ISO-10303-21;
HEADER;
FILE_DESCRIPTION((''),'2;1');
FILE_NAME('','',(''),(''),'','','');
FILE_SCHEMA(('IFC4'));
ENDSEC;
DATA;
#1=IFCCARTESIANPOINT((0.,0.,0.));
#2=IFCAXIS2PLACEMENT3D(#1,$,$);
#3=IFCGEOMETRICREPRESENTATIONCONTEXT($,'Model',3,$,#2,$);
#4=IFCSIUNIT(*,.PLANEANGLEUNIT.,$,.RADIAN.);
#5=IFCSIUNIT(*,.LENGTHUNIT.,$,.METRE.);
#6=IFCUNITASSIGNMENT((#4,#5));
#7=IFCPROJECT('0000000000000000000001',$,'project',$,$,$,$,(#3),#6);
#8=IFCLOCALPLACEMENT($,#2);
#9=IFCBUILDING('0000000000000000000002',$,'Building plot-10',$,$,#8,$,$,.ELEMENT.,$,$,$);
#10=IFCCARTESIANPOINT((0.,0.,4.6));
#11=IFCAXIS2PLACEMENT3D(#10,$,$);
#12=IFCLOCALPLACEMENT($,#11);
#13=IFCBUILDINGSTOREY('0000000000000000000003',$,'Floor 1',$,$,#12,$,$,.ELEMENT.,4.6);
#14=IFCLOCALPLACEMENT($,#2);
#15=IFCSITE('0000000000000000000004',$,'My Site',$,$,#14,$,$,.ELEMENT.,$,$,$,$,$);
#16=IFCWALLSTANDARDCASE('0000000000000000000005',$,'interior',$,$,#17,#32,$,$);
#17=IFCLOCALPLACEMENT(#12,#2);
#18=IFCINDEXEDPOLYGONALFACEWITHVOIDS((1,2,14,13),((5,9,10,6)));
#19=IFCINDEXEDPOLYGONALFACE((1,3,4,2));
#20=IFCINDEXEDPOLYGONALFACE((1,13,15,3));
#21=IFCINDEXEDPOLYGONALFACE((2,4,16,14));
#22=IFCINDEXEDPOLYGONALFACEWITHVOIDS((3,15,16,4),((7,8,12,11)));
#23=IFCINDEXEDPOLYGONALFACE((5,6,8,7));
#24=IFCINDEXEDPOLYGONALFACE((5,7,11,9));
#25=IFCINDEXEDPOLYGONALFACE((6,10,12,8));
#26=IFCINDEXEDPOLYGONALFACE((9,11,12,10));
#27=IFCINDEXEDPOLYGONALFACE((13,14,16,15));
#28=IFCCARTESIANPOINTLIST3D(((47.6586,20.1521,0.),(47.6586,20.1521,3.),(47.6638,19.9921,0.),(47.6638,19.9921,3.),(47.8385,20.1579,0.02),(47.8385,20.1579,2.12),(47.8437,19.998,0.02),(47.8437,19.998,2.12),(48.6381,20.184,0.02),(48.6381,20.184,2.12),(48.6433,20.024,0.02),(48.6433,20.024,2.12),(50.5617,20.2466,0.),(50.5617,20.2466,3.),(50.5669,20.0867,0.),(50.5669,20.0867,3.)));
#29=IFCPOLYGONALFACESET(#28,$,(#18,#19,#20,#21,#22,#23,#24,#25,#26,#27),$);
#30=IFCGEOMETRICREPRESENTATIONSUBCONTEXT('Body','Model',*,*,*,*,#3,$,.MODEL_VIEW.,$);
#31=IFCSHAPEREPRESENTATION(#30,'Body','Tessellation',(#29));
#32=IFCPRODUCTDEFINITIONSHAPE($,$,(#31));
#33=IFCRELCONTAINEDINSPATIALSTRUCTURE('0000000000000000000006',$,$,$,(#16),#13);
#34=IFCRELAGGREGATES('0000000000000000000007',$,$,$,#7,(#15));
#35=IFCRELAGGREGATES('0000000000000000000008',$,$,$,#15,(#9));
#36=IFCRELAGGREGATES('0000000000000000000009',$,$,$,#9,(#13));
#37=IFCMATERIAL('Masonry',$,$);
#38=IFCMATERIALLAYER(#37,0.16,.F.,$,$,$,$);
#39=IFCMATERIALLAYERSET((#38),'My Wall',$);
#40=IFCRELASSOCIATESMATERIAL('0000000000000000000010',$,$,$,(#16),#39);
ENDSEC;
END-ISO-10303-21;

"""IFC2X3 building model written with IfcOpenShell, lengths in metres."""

from ifc_helpers import new_model, si_unit, frame, origin, place, context, subcontext, project, spatial, polyline, outline, extrude, material, layer, layer_set, layer_usage, element, save


model = new_model("IFC2X3")

# Units and contexts
model_context = context("Model", 3, world=origin())
body_context = subcontext(model_context, "Body", "Model", "MODEL_VIEW")
ifc_project = project(units=[si_unit("PLANEANGLEUNIT", "RADIAN"), si_unit("LENGTHUNIT", "METRE")], contexts=[model_context])

# Site, building, storey
site_placement = place(None, origin())
site = spatial("IfcSite", under=ifc_project, at=site_placement, Name="My Site", CompositionType="ELEMENT")
building_placement = place(None, origin())
building = spatial("IfcBuilding", under=site, at=building_placement, Name="Building plot-10", CompositionType="ELEMENT")
storey_placement = place(None, frame((0.0, 0.0, 4.6)))
storey = spatial("IfcBuildingStorey", under=building, at=storey_placement, Name="Floor 1", CompositionType="ELEMENT", Elevation=4.6)

# Shared definitions
ifc_material_1 = material(Name="Masonry")
ifc_layer_1 = layer(ifc_material_1, 0.16, ventilated=False)
ifc_layer_set_1 = layer_set([ifc_layer_1], Name="My Wall")
ifc_layer_usage_1 = layer_usage(ifc_layer_set_1, "AXIS2", "NEGATIVE", 0.08)

# Wall, opening
wall_1_placement = place(storey_placement, origin())
wall_1 = element("IfcWallStandardCase", 1, at=wall_1_placement, inside=storey, material=ifc_layer_usage_1, Name="interior", context=body_context, shape_type="SweptSolid", body=[
    extrude(outline(polyline([(47.6586, 20.1521), (47.6638, 19.9921), (50.5669, 20.0867), (50.5617, 20.2466), (47.6586, 20.1521)])), origin(), (0.0, 0.0, 1.0), 3.0),
])
opening_1_placement = place(storey_placement, frame((0.0, 0.0, 0.02)))
element("IfcOpeningElement", 2, at=opening_1_placement, cuts=wall_1, ObjectType="Opening", context=body_context, shape_type="SweptSolid", body=[
    extrude(outline(polyline([(47.8437, 19.998), (48.6433, 20.024), (48.6381, 20.184), (47.8385, 20.1579), (47.8437, 19.998)])), origin(), (0.0, 0.0, 1.0), 2.1),
])

save(model, "model.ifc")
